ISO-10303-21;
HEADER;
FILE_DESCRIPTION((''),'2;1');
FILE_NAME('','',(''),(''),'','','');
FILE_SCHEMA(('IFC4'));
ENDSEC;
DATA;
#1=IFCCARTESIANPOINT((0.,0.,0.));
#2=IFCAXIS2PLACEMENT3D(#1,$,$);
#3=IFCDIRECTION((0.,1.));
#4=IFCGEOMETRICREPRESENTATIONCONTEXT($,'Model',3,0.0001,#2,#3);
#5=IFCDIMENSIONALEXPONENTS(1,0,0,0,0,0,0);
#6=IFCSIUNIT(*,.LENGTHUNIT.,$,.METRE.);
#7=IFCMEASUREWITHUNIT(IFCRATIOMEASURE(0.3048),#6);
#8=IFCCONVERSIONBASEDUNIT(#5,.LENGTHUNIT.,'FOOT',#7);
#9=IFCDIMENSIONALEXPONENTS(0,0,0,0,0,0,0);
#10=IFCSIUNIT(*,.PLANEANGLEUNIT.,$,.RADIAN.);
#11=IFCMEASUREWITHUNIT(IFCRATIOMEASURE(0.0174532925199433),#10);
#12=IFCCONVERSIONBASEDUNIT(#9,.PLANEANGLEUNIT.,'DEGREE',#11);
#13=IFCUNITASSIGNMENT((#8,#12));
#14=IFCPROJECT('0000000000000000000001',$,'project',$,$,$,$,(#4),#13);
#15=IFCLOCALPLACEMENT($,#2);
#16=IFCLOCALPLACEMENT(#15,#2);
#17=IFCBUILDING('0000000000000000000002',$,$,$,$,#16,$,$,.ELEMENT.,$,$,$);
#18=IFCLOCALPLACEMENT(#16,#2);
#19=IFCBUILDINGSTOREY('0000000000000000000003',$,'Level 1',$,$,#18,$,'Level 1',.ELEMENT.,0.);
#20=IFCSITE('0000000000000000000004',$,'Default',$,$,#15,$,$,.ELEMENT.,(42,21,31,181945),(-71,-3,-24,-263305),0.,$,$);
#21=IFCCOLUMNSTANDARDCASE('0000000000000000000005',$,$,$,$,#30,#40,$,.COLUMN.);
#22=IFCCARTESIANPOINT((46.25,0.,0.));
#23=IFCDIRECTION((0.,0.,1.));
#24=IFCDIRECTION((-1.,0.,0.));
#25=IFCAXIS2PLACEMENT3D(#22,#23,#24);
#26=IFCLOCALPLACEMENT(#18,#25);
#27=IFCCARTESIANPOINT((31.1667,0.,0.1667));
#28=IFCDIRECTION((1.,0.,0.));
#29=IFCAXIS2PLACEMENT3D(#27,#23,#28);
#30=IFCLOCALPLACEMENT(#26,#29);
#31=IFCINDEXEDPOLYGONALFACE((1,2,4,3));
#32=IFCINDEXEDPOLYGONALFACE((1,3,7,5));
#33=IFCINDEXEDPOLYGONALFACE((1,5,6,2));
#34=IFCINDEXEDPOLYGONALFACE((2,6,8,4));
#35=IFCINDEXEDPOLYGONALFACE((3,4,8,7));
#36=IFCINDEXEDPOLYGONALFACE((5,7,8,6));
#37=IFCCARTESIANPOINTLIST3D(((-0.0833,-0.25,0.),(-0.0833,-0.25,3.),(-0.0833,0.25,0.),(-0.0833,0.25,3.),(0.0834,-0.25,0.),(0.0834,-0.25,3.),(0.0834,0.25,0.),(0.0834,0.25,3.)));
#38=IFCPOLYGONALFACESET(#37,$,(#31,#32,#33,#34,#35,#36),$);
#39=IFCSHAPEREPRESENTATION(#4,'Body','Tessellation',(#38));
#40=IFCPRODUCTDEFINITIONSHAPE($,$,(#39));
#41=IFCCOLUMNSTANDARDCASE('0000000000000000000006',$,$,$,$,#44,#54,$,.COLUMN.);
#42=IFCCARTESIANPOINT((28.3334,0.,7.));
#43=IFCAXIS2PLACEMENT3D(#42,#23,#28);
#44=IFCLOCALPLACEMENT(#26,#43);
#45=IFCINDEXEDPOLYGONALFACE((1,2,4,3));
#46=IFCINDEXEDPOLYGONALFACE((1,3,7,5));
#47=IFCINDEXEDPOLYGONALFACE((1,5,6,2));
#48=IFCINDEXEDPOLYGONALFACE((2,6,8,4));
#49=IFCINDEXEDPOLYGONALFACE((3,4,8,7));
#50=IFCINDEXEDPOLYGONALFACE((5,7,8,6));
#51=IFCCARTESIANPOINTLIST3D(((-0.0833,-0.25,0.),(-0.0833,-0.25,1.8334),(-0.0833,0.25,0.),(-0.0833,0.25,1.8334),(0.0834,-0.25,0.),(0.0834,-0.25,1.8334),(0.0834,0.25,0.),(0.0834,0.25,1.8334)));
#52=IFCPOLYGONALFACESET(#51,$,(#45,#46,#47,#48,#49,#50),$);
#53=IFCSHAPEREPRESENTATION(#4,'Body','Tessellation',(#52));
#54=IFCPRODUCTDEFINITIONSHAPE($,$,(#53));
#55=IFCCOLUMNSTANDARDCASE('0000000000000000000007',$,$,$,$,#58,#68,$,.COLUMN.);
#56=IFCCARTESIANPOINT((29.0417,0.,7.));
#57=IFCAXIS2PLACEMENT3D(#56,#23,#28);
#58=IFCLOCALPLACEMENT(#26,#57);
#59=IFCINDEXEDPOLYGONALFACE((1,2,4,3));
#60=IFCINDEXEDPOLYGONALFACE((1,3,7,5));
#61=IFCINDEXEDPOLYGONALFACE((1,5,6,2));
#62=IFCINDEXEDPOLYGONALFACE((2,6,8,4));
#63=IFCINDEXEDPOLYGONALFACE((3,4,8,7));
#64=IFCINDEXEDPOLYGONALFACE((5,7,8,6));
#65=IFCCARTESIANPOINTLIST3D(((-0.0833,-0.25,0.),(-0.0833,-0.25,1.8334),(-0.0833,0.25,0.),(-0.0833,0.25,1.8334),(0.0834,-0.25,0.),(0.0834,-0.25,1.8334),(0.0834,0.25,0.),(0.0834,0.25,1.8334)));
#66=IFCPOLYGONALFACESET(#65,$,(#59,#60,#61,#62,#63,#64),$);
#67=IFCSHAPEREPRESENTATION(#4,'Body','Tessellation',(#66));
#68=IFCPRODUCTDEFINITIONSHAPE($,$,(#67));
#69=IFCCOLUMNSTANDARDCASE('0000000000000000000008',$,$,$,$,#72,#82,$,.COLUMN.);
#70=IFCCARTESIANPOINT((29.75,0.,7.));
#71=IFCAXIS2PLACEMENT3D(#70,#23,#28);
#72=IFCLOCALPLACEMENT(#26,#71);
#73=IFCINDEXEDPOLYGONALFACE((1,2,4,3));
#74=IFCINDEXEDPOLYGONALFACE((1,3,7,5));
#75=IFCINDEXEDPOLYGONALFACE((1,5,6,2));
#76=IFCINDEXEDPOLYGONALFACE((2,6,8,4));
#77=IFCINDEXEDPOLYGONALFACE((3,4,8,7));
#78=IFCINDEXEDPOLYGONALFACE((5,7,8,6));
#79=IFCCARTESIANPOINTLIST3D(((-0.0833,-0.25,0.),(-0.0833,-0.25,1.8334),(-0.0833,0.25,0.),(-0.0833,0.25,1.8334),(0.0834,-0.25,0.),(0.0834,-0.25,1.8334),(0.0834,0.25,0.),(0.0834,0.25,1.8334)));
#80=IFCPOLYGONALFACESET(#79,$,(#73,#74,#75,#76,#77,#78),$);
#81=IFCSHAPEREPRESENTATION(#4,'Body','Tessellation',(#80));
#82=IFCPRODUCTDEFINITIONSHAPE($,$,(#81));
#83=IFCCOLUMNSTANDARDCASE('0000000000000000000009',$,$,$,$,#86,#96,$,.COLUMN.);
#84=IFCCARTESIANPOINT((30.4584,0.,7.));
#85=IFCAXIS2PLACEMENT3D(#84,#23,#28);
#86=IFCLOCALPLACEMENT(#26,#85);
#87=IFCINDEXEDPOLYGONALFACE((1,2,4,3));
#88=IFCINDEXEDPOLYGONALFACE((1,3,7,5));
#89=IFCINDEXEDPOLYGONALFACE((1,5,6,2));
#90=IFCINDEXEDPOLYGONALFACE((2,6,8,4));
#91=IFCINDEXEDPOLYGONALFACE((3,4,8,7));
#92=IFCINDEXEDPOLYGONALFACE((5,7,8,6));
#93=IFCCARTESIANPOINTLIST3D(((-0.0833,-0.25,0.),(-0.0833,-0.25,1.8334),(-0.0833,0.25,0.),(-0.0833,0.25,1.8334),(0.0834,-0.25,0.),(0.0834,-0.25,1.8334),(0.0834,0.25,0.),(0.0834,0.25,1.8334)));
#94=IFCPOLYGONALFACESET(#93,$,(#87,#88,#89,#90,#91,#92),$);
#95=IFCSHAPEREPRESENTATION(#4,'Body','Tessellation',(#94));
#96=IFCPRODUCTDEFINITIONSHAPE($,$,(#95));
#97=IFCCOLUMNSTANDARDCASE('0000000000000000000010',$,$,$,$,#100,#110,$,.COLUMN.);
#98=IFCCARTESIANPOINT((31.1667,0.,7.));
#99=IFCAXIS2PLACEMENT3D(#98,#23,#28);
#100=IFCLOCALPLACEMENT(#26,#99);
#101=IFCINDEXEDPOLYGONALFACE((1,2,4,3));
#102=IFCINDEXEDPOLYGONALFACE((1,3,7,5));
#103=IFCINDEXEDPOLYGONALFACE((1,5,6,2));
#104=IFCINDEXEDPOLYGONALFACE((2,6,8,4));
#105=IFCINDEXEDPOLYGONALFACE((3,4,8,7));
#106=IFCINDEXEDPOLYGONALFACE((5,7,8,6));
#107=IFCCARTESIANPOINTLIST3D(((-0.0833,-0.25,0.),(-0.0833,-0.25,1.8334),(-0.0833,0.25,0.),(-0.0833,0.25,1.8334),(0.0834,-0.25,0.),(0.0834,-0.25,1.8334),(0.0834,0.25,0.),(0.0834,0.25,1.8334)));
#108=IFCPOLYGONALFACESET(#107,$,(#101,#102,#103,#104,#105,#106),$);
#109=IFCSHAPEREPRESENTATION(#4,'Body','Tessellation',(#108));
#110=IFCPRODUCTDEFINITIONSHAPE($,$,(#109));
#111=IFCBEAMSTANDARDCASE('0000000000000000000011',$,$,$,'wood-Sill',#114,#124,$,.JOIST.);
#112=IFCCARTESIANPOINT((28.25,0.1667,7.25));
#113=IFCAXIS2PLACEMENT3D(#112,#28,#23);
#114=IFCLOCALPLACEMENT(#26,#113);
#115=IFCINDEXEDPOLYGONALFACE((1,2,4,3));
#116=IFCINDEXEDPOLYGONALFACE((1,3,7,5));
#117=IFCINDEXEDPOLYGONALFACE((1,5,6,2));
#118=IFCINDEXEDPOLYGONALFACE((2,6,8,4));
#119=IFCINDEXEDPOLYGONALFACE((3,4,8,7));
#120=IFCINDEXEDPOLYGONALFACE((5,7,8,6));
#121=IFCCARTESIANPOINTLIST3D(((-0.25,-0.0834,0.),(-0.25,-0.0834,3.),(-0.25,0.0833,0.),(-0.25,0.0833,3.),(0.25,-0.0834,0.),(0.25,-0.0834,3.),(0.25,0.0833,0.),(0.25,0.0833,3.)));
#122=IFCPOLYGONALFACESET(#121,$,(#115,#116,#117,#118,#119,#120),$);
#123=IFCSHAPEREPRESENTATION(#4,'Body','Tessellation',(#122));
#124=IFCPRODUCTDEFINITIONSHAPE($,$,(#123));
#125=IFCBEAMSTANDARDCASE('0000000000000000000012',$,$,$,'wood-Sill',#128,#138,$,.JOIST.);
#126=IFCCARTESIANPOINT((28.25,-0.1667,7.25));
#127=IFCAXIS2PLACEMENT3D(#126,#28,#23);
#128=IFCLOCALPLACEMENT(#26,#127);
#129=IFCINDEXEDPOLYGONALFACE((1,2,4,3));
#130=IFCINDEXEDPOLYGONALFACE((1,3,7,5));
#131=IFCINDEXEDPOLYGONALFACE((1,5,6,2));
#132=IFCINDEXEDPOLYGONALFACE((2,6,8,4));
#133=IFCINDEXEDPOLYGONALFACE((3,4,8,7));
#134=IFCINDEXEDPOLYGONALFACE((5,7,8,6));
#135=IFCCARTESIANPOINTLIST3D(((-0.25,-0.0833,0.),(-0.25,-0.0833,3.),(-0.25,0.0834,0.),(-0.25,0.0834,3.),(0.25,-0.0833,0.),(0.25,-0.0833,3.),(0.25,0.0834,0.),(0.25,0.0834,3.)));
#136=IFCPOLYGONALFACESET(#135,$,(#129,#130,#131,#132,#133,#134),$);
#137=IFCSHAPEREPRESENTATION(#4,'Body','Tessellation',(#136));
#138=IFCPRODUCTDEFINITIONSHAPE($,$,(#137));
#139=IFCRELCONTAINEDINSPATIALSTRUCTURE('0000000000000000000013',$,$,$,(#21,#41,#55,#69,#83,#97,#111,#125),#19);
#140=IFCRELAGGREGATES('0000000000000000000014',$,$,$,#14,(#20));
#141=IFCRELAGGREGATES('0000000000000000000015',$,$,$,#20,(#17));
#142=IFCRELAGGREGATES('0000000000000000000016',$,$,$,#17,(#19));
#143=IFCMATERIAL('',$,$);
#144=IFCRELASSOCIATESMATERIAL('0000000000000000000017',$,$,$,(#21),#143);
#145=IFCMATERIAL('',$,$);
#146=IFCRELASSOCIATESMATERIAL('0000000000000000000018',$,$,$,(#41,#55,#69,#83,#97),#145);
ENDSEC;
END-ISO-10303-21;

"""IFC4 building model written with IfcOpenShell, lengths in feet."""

from ifc_helpers import new_model, entity, si_unit, converted_unit, direction, frame, origin, origin_with_axes, place, context, project, spatial, rectangle, extrude, material, element, save


model = new_model("IFC4")

# Units and contexts
model_context = context("Model", 3, precision=0.0001, world=origin(), true_north=direction((0.0, 1.0)))
ifc_project = project(units=[converted_unit("LENGTHUNIT", "FOOT", entity("IfcRatioMeasure", 0.3048), si_unit("LENGTHUNIT", "METRE"), dimensions=[1, 0, 0, 0, 0, 0, 0]), converted_unit("PLANEANGLEUNIT", "DEGREE", entity("IfcRatioMeasure", 0.0174532925199433), si_unit("PLANEANGLEUNIT", "RADIAN"), dimensions=[0, 0, 0, 0, 0, 0, 0])], contexts=[model_context])

# Site, building, storey
site_placement = place(None, origin())
site = spatial("IfcSite", under=ifc_project, at=site_placement, Name="Default", CompositionType="ELEMENT", RefLatitude=(42, 21, 31, 181945), RefLongitude=(-71, -3, -24, -263305), RefElevation=0.0)
building_placement = place(site_placement, origin())
building = spatial("IfcBuilding", under=site, at=building_placement, CompositionType="ELEMENT")
storey_placement = place(building_placement, origin())
storey = spatial("IfcBuildingStorey", under=building, at=storey_placement, Name="Level 1", LongName="Level 1", CompositionType="ELEMENT", Elevation=0.0)

# Columns
placement_1 = place(storey_placement, frame((46.25, 0.0, 0.0), z_axis=(0.0, 0.0, 1.0), x_axis=(-1.0, 0.0, 0.0)))
ifc_material_1 = material(Name="")
for number, where, z_axis, x_axis in (
    (1, (31.1667, 0.0, 0.1667), (0.0, 0.0, 1.0), (1.0, 0.0, 0.0)),
):
    element("IfcColumnStandardCase", number, at=place(placement_1, frame(where, z_axis=z_axis, x_axis=x_axis)), inside=storey, material=ifc_material_1, PredefinedType="COLUMN", context=model_context, shape_type="SweptSolid", body=[
        extrude(rectangle(XDim=0.1667, YDim=0.5), origin(), (0.0, 0.0, 1.0), 3.0),
    ])
ifc_material_2 = material(Name="")
for number, where, z_axis, x_axis in (
    (2, (28.3334, 0.0, 7.0), (0.0, 0.0, 1.0), (1.0, 0.0, 0.0)),
    (3, (29.0417, 0.0, 7.0), (0.0, 0.0, 1.0), (1.0, 0.0, 0.0)),
    (4, (29.75, 0.0, 7.0), (0.0, 0.0, 1.0), (1.0, 0.0, 0.0)),
    (5, (30.4584, 0.0, 7.0), (0.0, 0.0, 1.0), (1.0, 0.0, 0.0)),
    (6, (31.1667, 0.0, 7.0), (0.0, 0.0, 1.0), (1.0, 0.0, 0.0)),
):
    element("IfcColumnStandardCase", number, at=place(placement_1, frame(where, z_axis=z_axis, x_axis=x_axis)), inside=storey, material=ifc_material_2, PredefinedType="COLUMN", context=model_context, shape_type="SweptSolid", body=[
        extrude(rectangle(XDim=0.1667, YDim=0.5), origin(), (0.0, 0.0, 1.0), 1.8334),
    ])

# Beams
for number, where, z_axis, x_axis in (
    (7, (28.25, 0.1667, 7.25), (1.0, 0.0, 0.0), (0.0, 0.0, 1.0)),
    (8, (28.25, -0.1667, 7.25), (1.0, 0.0, 0.0), (0.0, 0.0, 1.0)),
):
    element("IfcBeamStandardCase", number, at=place(placement_1, frame(where, z_axis=z_axis, x_axis=x_axis)), inside=storey, ObjectType="wood-Sill", PredefinedType="JOIST", context=model_context, shape_type="SweptSolid", body=[
        extrude(rectangle(XDim=0.5, YDim=0.1667), origin_with_axes(), (0.0, 0.0, 1.0), 3.0),
    ])

save(model, "model.ifc")
